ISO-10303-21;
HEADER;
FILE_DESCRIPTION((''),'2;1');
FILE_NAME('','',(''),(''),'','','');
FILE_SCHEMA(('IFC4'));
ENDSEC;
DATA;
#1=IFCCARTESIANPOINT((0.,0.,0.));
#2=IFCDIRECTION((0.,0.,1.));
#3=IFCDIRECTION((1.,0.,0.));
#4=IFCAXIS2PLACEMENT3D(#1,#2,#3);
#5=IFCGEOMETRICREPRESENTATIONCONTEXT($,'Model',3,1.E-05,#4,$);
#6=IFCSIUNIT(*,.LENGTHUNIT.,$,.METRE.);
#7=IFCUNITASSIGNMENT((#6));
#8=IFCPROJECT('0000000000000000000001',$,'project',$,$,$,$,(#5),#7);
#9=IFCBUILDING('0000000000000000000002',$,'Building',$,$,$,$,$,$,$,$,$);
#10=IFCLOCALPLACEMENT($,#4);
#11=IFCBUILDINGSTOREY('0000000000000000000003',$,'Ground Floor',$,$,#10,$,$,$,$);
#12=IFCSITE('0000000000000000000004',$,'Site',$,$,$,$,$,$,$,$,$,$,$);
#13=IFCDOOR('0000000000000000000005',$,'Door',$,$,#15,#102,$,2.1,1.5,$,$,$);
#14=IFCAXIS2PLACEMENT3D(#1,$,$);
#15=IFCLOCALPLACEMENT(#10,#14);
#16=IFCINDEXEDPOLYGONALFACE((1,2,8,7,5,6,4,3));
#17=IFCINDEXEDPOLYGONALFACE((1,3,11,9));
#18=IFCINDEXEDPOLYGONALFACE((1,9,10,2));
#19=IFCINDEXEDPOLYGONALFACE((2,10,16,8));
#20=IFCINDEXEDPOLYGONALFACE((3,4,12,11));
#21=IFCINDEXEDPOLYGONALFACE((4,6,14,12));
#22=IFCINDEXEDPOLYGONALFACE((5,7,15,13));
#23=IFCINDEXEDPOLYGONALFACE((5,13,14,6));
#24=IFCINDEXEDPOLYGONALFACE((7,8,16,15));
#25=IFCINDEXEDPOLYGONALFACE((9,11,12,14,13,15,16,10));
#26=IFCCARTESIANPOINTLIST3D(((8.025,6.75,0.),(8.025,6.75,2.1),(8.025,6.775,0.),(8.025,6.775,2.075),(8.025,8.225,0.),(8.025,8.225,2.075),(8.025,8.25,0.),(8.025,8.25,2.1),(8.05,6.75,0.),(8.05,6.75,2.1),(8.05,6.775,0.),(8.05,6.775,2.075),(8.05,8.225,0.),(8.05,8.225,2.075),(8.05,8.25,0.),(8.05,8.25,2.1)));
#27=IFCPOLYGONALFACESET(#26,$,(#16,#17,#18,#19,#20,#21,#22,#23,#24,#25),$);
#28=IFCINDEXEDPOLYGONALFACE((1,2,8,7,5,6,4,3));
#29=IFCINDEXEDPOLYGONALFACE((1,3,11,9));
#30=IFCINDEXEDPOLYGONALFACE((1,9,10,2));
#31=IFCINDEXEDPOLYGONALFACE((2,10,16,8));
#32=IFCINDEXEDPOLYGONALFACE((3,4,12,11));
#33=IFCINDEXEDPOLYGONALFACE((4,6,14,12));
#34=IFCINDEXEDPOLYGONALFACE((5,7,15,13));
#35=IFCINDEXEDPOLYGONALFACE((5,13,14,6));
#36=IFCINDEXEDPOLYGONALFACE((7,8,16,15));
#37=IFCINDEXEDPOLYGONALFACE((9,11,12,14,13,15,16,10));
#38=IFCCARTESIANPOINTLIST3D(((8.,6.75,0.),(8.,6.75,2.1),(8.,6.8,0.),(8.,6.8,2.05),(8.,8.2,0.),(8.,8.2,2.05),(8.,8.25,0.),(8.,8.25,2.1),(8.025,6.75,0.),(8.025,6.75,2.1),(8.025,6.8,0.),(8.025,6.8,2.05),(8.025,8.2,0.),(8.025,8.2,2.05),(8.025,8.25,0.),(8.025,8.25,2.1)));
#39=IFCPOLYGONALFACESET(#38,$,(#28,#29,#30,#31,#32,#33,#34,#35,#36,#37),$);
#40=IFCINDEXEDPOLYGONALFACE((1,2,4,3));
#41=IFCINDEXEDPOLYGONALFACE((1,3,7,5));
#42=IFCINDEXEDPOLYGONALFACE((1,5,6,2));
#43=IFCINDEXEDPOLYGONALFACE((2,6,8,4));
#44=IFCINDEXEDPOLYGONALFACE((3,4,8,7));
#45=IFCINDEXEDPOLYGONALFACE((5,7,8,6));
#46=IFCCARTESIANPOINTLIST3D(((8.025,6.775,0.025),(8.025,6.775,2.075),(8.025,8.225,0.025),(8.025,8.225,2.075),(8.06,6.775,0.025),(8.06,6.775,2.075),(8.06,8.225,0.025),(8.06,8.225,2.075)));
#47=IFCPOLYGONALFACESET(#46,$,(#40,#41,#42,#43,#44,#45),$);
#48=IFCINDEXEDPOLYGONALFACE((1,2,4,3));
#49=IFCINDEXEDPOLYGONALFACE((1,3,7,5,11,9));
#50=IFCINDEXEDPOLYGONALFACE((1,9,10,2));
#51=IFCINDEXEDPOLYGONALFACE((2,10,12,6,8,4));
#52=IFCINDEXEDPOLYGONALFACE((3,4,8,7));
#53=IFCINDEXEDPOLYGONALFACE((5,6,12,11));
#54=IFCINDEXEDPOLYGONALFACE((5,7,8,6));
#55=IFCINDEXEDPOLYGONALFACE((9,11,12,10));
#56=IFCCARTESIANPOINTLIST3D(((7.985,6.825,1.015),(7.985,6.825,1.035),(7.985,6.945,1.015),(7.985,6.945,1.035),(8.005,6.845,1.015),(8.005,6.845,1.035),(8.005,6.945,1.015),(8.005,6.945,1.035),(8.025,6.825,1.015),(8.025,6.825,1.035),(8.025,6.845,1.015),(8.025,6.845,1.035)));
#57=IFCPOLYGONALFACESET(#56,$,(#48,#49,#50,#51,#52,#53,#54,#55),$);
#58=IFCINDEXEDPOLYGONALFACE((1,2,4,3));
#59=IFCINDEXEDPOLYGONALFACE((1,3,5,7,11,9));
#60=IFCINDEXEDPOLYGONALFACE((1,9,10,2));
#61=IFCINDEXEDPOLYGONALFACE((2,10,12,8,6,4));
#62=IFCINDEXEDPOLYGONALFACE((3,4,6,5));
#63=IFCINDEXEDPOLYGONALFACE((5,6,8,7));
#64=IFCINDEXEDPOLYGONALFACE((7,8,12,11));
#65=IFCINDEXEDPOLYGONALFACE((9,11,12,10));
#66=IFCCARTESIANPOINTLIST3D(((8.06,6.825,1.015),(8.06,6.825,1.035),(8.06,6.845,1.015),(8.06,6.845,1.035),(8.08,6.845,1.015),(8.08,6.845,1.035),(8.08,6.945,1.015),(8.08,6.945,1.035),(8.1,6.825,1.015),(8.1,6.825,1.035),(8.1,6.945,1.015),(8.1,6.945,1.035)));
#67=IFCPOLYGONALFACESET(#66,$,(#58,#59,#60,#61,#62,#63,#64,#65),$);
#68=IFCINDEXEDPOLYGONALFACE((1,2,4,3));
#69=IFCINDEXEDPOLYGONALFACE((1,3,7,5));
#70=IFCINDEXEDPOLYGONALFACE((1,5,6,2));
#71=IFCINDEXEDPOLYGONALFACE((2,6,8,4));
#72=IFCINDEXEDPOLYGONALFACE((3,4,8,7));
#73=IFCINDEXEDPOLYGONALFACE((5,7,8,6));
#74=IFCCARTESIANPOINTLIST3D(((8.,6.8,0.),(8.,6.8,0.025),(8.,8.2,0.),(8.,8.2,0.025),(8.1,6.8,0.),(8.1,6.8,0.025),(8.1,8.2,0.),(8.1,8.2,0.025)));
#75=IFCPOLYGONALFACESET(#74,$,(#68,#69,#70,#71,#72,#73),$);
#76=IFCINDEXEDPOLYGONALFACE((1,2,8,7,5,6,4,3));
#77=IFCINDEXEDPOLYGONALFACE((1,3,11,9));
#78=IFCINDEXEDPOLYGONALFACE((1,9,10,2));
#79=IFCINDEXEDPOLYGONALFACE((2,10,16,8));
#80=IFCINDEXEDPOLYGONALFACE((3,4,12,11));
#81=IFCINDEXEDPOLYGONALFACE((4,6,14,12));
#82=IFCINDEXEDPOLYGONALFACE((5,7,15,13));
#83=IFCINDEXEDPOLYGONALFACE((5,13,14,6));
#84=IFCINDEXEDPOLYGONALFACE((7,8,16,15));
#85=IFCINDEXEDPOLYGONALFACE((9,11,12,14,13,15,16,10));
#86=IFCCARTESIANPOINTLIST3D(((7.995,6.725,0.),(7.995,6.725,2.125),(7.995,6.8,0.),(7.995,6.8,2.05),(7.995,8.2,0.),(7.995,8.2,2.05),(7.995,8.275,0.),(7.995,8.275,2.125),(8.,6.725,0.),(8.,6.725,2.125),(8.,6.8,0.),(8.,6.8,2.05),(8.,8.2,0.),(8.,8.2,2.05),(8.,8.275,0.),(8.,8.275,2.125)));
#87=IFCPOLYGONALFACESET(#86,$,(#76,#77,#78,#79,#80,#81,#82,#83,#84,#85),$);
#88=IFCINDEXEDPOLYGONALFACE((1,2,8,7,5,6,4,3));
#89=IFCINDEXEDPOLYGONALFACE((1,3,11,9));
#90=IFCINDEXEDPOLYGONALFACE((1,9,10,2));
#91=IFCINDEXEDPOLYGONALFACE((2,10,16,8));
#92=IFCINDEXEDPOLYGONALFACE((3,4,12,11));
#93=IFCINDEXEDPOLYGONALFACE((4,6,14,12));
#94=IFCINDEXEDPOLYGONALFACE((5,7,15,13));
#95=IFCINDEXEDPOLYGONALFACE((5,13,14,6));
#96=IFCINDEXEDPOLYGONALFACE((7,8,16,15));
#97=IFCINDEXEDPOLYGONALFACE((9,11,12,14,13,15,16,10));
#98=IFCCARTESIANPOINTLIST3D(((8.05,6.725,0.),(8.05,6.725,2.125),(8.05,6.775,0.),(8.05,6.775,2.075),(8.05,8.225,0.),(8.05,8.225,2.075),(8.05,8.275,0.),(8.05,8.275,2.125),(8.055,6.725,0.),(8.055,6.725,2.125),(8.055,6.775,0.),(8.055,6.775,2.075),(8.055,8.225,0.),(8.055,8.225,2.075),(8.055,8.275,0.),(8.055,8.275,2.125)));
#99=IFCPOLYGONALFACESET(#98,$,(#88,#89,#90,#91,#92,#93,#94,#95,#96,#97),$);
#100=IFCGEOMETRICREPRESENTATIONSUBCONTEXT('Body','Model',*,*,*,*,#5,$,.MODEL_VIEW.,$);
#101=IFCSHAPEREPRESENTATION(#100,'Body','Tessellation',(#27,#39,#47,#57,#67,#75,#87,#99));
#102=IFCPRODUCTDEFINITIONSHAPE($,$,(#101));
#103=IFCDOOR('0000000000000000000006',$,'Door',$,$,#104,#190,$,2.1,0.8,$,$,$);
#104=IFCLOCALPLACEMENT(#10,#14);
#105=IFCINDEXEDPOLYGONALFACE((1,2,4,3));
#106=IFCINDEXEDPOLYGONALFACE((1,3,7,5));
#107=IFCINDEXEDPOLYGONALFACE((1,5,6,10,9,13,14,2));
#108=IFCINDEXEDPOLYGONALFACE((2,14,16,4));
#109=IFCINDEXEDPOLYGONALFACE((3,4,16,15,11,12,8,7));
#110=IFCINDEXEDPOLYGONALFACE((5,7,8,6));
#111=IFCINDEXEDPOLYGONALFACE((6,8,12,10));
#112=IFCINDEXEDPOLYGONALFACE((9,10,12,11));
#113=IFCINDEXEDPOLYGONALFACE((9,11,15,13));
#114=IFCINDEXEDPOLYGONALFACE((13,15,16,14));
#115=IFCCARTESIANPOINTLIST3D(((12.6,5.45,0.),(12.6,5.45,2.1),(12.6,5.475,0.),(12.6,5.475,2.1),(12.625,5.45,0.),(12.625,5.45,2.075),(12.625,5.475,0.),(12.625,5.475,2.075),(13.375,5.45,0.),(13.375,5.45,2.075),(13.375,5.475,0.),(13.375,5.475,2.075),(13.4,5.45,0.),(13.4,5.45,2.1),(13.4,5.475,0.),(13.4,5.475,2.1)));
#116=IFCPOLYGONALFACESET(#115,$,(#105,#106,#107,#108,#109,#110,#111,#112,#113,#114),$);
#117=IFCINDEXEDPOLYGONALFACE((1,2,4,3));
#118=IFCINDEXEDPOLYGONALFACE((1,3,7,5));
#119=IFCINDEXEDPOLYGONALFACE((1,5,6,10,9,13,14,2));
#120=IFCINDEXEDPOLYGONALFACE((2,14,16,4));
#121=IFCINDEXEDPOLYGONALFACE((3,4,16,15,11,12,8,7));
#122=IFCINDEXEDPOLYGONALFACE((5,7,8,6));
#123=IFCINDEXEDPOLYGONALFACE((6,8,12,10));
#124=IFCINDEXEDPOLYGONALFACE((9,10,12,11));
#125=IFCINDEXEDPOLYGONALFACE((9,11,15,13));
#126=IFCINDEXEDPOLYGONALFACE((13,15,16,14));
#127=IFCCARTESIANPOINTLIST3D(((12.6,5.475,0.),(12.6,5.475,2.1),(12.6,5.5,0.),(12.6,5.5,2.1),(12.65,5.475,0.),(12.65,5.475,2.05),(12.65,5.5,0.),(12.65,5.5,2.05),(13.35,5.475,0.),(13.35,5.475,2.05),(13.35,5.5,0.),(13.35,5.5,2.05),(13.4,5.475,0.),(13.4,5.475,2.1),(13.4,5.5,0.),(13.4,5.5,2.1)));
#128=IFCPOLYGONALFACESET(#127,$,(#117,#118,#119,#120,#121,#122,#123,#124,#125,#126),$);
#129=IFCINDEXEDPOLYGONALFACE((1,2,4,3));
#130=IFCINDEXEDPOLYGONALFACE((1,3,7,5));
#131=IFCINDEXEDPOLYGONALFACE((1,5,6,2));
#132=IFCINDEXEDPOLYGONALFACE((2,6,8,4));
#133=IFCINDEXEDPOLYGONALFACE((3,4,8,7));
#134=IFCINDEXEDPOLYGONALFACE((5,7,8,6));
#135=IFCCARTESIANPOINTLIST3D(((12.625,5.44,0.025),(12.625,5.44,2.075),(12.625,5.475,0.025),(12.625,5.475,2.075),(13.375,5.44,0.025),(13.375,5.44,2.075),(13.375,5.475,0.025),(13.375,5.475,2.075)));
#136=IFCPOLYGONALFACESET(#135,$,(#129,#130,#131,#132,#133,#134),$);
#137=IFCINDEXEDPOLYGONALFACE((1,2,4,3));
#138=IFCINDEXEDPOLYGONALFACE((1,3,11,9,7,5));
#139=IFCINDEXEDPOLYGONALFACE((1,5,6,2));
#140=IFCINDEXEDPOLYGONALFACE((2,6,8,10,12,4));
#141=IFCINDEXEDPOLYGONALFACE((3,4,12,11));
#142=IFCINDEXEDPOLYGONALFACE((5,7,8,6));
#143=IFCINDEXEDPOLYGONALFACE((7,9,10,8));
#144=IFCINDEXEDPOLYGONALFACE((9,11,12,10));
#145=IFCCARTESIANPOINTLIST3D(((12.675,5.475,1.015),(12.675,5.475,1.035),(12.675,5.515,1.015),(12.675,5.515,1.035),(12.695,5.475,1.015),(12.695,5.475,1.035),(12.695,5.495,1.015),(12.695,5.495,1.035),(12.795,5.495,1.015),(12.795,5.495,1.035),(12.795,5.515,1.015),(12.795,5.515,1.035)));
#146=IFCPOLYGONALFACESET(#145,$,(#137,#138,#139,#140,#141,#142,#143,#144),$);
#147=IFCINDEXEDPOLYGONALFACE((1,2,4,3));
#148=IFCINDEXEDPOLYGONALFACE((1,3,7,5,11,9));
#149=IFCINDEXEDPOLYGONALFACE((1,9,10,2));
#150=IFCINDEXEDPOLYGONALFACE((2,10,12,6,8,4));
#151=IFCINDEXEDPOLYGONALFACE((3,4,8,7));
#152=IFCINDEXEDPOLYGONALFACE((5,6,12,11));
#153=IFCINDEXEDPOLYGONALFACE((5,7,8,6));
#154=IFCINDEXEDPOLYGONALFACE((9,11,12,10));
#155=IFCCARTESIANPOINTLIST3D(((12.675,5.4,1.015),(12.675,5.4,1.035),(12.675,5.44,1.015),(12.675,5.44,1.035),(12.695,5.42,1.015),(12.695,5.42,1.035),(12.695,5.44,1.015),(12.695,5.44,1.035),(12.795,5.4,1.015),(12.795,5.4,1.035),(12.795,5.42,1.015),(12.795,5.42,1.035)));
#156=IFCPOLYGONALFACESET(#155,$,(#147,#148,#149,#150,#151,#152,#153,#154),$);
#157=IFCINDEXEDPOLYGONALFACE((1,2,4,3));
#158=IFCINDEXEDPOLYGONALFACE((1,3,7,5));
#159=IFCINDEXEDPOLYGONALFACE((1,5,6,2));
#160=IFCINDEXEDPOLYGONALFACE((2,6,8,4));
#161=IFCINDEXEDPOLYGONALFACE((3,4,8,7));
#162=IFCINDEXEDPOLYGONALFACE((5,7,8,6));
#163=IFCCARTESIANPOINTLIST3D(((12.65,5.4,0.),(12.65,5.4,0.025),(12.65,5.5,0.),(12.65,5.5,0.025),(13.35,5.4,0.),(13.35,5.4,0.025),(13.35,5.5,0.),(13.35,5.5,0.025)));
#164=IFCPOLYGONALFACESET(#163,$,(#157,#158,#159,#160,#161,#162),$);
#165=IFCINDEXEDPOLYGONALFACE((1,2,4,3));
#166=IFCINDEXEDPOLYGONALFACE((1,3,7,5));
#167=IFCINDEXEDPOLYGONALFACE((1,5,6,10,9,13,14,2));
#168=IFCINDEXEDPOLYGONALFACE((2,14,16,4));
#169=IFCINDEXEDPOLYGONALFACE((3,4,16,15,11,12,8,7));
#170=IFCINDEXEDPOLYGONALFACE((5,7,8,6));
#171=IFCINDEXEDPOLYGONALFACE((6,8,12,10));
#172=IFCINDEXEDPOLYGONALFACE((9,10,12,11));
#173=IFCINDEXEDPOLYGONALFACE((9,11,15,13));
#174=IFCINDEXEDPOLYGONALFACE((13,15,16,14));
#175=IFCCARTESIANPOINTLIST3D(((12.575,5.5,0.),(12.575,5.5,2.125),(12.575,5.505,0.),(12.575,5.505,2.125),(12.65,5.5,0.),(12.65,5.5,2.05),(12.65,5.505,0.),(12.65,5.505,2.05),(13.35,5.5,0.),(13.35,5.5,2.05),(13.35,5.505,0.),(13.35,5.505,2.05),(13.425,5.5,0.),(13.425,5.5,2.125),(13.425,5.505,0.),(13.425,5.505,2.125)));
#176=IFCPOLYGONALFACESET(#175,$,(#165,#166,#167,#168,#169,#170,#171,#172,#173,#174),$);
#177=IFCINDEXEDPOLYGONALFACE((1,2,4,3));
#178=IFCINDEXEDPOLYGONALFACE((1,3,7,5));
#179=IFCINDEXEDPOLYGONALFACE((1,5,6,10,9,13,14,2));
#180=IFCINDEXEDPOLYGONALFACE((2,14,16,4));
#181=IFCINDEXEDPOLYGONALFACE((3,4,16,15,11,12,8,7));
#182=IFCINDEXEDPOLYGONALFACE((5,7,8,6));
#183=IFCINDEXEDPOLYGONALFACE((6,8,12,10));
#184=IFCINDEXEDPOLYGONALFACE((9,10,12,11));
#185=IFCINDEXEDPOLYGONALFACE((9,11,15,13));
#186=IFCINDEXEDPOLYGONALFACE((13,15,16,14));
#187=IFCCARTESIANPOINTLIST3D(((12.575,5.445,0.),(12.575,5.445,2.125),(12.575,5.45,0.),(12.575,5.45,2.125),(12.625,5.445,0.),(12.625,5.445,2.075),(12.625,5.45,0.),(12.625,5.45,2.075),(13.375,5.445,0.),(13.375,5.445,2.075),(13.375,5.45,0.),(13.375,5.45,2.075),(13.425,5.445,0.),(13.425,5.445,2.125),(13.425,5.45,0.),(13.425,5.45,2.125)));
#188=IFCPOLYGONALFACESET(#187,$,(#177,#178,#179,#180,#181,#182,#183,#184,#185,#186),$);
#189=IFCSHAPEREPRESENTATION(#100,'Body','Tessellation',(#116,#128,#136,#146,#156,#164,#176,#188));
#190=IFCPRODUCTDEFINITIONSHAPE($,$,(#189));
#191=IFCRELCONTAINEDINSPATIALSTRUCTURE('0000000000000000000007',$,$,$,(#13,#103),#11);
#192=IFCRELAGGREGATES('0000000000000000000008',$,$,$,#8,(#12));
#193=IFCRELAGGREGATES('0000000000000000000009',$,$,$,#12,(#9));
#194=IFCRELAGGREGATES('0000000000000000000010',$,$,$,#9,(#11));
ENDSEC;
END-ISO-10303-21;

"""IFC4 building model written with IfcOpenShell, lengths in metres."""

from ifc_helpers import new_model, si_unit, frame, origin_with_axes, place, context, subcontext, project, spatial, line, indexed_curve, outline, extrude, element, save


model = new_model("IFC4")

# Units and contexts
model_context = context("Model", 3, precision=1e-05, world=origin_with_axes())
body_context = subcontext(model_context, "Body", "Model", "MODEL_VIEW")
ifc_project = project(units=[si_unit("LENGTHUNIT", "METRE")], contexts=[model_context])

# Site, building, storey
site = spatial("IfcSite", under=ifc_project, Name="Site")
building = spatial("IfcBuilding", under=site, Name="Building")
storey_placement = place(None, origin_with_axes())
storey = spatial("IfcBuildingStorey", under=building, at=storey_placement, Name="Ground Floor")

# Doors
door_1_placement = place(storey_placement, frame((8.0, 8.25, 0.0), z_axis=(0.0, 0.0, 1.0), x_axis=(0.0, -1.0, 0.0)))
element("IfcDoor", 1, at=door_1_placement, inside=storey, Name="Door", OverallHeight=2.1, OverallWidth=1.5, context=body_context, shape_type="SweptSolid", body=[
    extrude(outline(indexed_curve([(0.0, 0.0), (0.0, 2.1), (1.5, 2.1), (1.5, 0.0), (1.475, 0.0), (1.475, 2.075), (0.025, 2.075), (0.025, 0.0)], segments=[line(1, 2, 3, 4, 5, 6, 7, 8, 1)])), frame((0.0, 0.025, 0.0), z_axis=(0.0, -1.0, 0.0), x_axis=(1.0, 0.0, 0.0)), (0.0, 0.0, -1.0), 0.025),
    extrude(outline(indexed_curve([(0.0, 0.0), (0.0, 2.1), (1.5, 2.1), (1.5, 0.0), (1.45, 0.0), (1.45, 2.05), (0.05, 2.05), (0.05, 0.0)], segments=[line(1, 2, 3, 4, 5, 6, 7, 8, 1)])), frame((0.0, 0.0, 0.0), z_axis=(0.0, -1.0, 0.0), x_axis=(1.0, 0.0, 0.0)), (0.0, 0.0, -1.0), 0.025),
    extrude(outline(indexed_curve([(0.0, 0.0), (1.45, 0.0), (1.45, 0.035), (0.0, 0.035)], segments=[line(1, 2, 3, 4, 1)])), frame((0.025, 0.025, 0.025), z_axis=(0.0, 0.0, 1.0), x_axis=(1.0, 0.0, 0.0)), (0.0, 0.0, 1.0), 2.05),
    extrude(outline(indexed_curve([(0.0, 0.0), (0.0, -0.04), (-0.12, -0.04), (-0.12, -0.02), (-0.02, -0.02), (-0.02, 0.0)], segments=[line(1, 2, 3, 4, 5, 6, 1)])), frame((1.425, 0.025, 1.015), z_axis=(0.0, 0.0, 1.0), x_axis=(1.0, 0.0, 0.0)), (0.0, 0.0, 1.0), 0.02),
    extrude(outline(indexed_curve([(0.0, 0.0), (0.0, 0.04), (-0.12, 0.04), (-0.12, 0.02), (-0.02, 0.02), (-0.02, 0.0)], segments=[line(1, 2, 3, 4, 5, 6, 1)])), frame((1.425, 0.06, 1.015), z_axis=(0.0, 0.0, 1.0), x_axis=(1.0, 0.0, 0.0)), (0.0, 0.0, 1.0), 0.02),
    extrude(outline(indexed_curve([(0.0, 0.0), (1.4, 0.0), (1.4, 0.1), (0.0, 0.1)], segments=[line(1, 2, 3, 4, 1)])), frame((0.05, 0.0, 0.0), z_axis=(0.0, 0.0, 1.0), x_axis=(1.0, 0.0, 0.0)), (0.0, 0.0, 1.0), 0.025),
    extrude(outline(indexed_curve([(0.0, 0.0), (0.0, 2.125), (1.55, 2.125), (1.55, 0.0), (1.475, 0.0), (1.475, 2.05), (0.075, 2.05), (0.075, 0.0)], segments=[line(1, 2, 3, 4, 5, 6, 7, 8, 1)])), frame((-0.025, -0.005, 0.0), z_axis=(0.0, -1.0, 0.0), x_axis=(1.0, 0.0, 0.0)), (0.0, 0.0, -1.0), 0.005),
    extrude(outline(indexed_curve([(0.0, 0.0), (0.0, 2.125), (1.55, 2.125), (1.55, 0.0), (1.5, 0.0), (1.5, 2.075), (0.05, 2.075), (0.05, 0.0)], segments=[line(1, 2, 3, 4, 5, 6, 7, 8, 1)])), frame((-0.025, 0.05, 0.0), z_axis=(0.0, -1.0, 0.0), x_axis=(1.0, 0.0, 0.0)), (0.0, 0.0, -1.0), 0.005),
])
door_2_placement = place(storey_placement, frame((13.4, 5.5, 0.0), z_axis=(0.0, 0.0, 1.0), x_axis=(-1.0, 0.0, 0.0)))
element("IfcDoor", 2, at=door_2_placement, inside=storey, Name="Door", OverallHeight=2.1, OverallWidth=0.8, context=body_context, shape_type="SweptSolid", body=[
    extrude(outline(indexed_curve([(0.0, 0.0), (0.0, 2.1), (0.8, 2.1), (0.8, 0.0), (0.775, 0.0), (0.775, 2.075), (0.025, 2.075), (0.025, 0.0)], segments=[line(1, 2, 3, 4, 5, 6, 7, 8, 1)])), frame((0.0, 0.025, 0.0), z_axis=(0.0, -1.0, 0.0), x_axis=(1.0, 0.0, 0.0)), (0.0, 0.0, -1.0), 0.025),
    extrude(outline(indexed_curve([(0.0, 0.0), (0.0, 2.1), (0.8, 2.1), (0.8, 0.0), (0.75, 0.0), (0.75, 2.05), (0.05, 2.05), (0.05, 0.0)], segments=[line(1, 2, 3, 4, 5, 6, 7, 8, 1)])), frame((0.0, 0.0, 0.0), z_axis=(0.0, -1.0, 0.0), x_axis=(1.0, 0.0, 0.0)), (0.0, 0.0, -1.0), 0.025),
    extrude(outline(indexed_curve([(0.0, 0.0), (0.75, 0.0), (0.75, 0.035), (0.0, 0.035)], segments=[line(1, 2, 3, 4, 1)])), frame((0.025, 0.025, 0.025), z_axis=(0.0, 0.0, 1.0), x_axis=(1.0, 0.0, 0.0)), (0.0, 0.0, 1.0), 2.05),
    extrude(outline(indexed_curve([(0.0, 0.0), (0.0, -0.04), (-0.12, -0.04), (-0.12, -0.02), (-0.02, -0.02), (-0.02, 0.0)], segments=[line(1, 2, 3, 4, 5, 6, 1)])), frame((0.725, 0.025, 1.015), z_axis=(0.0, 0.0, 1.0), x_axis=(1.0, 0.0, 0.0)), (0.0, 0.0, 1.0), 0.02),
    extrude(outline(indexed_curve([(0.0, 0.0), (0.0, 0.04), (-0.12, 0.04), (-0.12, 0.02), (-0.02, 0.02), (-0.02, 0.0)], segments=[line(1, 2, 3, 4, 5, 6, 1)])), frame((0.725, 0.06, 1.015), z_axis=(0.0, 0.0, 1.0), x_axis=(1.0, 0.0, 0.0)), (0.0, 0.0, 1.0), 0.02),
    extrude(outline(indexed_curve([(0.0, 0.0), (0.7, 0.0), (0.7, 0.1), (0.0, 0.1)], segments=[line(1, 2, 3, 4, 1)])), frame((0.05, 0.0, 0.0), z_axis=(0.0, 0.0, 1.0), x_axis=(1.0, 0.0, 0.0)), (0.0, 0.0, 1.0), 0.025),
    extrude(outline(indexed_curve([(0.0, 0.0), (0.0, 2.125), (0.85, 2.125), (0.85, 0.0), (0.775, 0.0), (0.775, 2.05), (0.075, 2.05), (0.075, 0.0)], segments=[line(1, 2, 3, 4, 5, 6, 7, 8, 1)])), frame((-0.025, -0.005, 0.0), z_axis=(0.0, -1.0, 0.0), x_axis=(1.0, 0.0, 0.0)), (0.0, 0.0, -1.0), 0.005),
    extrude(outline(indexed_curve([(0.0, 0.0), (0.0, 2.125), (0.85, 2.125), (0.85, 0.0), (0.8, 0.0), (0.8, 2.075), (0.05, 2.075), (0.05, 0.0)], segments=[line(1, 2, 3, 4, 5, 6, 7, 8, 1)])), frame((-0.025, 0.05, 0.0), z_axis=(0.0, -1.0, 0.0), x_axis=(1.0, 0.0, 0.0)), (0.0, 0.0, -1.0), 0.005),
])

save(model, "model.ifc")
